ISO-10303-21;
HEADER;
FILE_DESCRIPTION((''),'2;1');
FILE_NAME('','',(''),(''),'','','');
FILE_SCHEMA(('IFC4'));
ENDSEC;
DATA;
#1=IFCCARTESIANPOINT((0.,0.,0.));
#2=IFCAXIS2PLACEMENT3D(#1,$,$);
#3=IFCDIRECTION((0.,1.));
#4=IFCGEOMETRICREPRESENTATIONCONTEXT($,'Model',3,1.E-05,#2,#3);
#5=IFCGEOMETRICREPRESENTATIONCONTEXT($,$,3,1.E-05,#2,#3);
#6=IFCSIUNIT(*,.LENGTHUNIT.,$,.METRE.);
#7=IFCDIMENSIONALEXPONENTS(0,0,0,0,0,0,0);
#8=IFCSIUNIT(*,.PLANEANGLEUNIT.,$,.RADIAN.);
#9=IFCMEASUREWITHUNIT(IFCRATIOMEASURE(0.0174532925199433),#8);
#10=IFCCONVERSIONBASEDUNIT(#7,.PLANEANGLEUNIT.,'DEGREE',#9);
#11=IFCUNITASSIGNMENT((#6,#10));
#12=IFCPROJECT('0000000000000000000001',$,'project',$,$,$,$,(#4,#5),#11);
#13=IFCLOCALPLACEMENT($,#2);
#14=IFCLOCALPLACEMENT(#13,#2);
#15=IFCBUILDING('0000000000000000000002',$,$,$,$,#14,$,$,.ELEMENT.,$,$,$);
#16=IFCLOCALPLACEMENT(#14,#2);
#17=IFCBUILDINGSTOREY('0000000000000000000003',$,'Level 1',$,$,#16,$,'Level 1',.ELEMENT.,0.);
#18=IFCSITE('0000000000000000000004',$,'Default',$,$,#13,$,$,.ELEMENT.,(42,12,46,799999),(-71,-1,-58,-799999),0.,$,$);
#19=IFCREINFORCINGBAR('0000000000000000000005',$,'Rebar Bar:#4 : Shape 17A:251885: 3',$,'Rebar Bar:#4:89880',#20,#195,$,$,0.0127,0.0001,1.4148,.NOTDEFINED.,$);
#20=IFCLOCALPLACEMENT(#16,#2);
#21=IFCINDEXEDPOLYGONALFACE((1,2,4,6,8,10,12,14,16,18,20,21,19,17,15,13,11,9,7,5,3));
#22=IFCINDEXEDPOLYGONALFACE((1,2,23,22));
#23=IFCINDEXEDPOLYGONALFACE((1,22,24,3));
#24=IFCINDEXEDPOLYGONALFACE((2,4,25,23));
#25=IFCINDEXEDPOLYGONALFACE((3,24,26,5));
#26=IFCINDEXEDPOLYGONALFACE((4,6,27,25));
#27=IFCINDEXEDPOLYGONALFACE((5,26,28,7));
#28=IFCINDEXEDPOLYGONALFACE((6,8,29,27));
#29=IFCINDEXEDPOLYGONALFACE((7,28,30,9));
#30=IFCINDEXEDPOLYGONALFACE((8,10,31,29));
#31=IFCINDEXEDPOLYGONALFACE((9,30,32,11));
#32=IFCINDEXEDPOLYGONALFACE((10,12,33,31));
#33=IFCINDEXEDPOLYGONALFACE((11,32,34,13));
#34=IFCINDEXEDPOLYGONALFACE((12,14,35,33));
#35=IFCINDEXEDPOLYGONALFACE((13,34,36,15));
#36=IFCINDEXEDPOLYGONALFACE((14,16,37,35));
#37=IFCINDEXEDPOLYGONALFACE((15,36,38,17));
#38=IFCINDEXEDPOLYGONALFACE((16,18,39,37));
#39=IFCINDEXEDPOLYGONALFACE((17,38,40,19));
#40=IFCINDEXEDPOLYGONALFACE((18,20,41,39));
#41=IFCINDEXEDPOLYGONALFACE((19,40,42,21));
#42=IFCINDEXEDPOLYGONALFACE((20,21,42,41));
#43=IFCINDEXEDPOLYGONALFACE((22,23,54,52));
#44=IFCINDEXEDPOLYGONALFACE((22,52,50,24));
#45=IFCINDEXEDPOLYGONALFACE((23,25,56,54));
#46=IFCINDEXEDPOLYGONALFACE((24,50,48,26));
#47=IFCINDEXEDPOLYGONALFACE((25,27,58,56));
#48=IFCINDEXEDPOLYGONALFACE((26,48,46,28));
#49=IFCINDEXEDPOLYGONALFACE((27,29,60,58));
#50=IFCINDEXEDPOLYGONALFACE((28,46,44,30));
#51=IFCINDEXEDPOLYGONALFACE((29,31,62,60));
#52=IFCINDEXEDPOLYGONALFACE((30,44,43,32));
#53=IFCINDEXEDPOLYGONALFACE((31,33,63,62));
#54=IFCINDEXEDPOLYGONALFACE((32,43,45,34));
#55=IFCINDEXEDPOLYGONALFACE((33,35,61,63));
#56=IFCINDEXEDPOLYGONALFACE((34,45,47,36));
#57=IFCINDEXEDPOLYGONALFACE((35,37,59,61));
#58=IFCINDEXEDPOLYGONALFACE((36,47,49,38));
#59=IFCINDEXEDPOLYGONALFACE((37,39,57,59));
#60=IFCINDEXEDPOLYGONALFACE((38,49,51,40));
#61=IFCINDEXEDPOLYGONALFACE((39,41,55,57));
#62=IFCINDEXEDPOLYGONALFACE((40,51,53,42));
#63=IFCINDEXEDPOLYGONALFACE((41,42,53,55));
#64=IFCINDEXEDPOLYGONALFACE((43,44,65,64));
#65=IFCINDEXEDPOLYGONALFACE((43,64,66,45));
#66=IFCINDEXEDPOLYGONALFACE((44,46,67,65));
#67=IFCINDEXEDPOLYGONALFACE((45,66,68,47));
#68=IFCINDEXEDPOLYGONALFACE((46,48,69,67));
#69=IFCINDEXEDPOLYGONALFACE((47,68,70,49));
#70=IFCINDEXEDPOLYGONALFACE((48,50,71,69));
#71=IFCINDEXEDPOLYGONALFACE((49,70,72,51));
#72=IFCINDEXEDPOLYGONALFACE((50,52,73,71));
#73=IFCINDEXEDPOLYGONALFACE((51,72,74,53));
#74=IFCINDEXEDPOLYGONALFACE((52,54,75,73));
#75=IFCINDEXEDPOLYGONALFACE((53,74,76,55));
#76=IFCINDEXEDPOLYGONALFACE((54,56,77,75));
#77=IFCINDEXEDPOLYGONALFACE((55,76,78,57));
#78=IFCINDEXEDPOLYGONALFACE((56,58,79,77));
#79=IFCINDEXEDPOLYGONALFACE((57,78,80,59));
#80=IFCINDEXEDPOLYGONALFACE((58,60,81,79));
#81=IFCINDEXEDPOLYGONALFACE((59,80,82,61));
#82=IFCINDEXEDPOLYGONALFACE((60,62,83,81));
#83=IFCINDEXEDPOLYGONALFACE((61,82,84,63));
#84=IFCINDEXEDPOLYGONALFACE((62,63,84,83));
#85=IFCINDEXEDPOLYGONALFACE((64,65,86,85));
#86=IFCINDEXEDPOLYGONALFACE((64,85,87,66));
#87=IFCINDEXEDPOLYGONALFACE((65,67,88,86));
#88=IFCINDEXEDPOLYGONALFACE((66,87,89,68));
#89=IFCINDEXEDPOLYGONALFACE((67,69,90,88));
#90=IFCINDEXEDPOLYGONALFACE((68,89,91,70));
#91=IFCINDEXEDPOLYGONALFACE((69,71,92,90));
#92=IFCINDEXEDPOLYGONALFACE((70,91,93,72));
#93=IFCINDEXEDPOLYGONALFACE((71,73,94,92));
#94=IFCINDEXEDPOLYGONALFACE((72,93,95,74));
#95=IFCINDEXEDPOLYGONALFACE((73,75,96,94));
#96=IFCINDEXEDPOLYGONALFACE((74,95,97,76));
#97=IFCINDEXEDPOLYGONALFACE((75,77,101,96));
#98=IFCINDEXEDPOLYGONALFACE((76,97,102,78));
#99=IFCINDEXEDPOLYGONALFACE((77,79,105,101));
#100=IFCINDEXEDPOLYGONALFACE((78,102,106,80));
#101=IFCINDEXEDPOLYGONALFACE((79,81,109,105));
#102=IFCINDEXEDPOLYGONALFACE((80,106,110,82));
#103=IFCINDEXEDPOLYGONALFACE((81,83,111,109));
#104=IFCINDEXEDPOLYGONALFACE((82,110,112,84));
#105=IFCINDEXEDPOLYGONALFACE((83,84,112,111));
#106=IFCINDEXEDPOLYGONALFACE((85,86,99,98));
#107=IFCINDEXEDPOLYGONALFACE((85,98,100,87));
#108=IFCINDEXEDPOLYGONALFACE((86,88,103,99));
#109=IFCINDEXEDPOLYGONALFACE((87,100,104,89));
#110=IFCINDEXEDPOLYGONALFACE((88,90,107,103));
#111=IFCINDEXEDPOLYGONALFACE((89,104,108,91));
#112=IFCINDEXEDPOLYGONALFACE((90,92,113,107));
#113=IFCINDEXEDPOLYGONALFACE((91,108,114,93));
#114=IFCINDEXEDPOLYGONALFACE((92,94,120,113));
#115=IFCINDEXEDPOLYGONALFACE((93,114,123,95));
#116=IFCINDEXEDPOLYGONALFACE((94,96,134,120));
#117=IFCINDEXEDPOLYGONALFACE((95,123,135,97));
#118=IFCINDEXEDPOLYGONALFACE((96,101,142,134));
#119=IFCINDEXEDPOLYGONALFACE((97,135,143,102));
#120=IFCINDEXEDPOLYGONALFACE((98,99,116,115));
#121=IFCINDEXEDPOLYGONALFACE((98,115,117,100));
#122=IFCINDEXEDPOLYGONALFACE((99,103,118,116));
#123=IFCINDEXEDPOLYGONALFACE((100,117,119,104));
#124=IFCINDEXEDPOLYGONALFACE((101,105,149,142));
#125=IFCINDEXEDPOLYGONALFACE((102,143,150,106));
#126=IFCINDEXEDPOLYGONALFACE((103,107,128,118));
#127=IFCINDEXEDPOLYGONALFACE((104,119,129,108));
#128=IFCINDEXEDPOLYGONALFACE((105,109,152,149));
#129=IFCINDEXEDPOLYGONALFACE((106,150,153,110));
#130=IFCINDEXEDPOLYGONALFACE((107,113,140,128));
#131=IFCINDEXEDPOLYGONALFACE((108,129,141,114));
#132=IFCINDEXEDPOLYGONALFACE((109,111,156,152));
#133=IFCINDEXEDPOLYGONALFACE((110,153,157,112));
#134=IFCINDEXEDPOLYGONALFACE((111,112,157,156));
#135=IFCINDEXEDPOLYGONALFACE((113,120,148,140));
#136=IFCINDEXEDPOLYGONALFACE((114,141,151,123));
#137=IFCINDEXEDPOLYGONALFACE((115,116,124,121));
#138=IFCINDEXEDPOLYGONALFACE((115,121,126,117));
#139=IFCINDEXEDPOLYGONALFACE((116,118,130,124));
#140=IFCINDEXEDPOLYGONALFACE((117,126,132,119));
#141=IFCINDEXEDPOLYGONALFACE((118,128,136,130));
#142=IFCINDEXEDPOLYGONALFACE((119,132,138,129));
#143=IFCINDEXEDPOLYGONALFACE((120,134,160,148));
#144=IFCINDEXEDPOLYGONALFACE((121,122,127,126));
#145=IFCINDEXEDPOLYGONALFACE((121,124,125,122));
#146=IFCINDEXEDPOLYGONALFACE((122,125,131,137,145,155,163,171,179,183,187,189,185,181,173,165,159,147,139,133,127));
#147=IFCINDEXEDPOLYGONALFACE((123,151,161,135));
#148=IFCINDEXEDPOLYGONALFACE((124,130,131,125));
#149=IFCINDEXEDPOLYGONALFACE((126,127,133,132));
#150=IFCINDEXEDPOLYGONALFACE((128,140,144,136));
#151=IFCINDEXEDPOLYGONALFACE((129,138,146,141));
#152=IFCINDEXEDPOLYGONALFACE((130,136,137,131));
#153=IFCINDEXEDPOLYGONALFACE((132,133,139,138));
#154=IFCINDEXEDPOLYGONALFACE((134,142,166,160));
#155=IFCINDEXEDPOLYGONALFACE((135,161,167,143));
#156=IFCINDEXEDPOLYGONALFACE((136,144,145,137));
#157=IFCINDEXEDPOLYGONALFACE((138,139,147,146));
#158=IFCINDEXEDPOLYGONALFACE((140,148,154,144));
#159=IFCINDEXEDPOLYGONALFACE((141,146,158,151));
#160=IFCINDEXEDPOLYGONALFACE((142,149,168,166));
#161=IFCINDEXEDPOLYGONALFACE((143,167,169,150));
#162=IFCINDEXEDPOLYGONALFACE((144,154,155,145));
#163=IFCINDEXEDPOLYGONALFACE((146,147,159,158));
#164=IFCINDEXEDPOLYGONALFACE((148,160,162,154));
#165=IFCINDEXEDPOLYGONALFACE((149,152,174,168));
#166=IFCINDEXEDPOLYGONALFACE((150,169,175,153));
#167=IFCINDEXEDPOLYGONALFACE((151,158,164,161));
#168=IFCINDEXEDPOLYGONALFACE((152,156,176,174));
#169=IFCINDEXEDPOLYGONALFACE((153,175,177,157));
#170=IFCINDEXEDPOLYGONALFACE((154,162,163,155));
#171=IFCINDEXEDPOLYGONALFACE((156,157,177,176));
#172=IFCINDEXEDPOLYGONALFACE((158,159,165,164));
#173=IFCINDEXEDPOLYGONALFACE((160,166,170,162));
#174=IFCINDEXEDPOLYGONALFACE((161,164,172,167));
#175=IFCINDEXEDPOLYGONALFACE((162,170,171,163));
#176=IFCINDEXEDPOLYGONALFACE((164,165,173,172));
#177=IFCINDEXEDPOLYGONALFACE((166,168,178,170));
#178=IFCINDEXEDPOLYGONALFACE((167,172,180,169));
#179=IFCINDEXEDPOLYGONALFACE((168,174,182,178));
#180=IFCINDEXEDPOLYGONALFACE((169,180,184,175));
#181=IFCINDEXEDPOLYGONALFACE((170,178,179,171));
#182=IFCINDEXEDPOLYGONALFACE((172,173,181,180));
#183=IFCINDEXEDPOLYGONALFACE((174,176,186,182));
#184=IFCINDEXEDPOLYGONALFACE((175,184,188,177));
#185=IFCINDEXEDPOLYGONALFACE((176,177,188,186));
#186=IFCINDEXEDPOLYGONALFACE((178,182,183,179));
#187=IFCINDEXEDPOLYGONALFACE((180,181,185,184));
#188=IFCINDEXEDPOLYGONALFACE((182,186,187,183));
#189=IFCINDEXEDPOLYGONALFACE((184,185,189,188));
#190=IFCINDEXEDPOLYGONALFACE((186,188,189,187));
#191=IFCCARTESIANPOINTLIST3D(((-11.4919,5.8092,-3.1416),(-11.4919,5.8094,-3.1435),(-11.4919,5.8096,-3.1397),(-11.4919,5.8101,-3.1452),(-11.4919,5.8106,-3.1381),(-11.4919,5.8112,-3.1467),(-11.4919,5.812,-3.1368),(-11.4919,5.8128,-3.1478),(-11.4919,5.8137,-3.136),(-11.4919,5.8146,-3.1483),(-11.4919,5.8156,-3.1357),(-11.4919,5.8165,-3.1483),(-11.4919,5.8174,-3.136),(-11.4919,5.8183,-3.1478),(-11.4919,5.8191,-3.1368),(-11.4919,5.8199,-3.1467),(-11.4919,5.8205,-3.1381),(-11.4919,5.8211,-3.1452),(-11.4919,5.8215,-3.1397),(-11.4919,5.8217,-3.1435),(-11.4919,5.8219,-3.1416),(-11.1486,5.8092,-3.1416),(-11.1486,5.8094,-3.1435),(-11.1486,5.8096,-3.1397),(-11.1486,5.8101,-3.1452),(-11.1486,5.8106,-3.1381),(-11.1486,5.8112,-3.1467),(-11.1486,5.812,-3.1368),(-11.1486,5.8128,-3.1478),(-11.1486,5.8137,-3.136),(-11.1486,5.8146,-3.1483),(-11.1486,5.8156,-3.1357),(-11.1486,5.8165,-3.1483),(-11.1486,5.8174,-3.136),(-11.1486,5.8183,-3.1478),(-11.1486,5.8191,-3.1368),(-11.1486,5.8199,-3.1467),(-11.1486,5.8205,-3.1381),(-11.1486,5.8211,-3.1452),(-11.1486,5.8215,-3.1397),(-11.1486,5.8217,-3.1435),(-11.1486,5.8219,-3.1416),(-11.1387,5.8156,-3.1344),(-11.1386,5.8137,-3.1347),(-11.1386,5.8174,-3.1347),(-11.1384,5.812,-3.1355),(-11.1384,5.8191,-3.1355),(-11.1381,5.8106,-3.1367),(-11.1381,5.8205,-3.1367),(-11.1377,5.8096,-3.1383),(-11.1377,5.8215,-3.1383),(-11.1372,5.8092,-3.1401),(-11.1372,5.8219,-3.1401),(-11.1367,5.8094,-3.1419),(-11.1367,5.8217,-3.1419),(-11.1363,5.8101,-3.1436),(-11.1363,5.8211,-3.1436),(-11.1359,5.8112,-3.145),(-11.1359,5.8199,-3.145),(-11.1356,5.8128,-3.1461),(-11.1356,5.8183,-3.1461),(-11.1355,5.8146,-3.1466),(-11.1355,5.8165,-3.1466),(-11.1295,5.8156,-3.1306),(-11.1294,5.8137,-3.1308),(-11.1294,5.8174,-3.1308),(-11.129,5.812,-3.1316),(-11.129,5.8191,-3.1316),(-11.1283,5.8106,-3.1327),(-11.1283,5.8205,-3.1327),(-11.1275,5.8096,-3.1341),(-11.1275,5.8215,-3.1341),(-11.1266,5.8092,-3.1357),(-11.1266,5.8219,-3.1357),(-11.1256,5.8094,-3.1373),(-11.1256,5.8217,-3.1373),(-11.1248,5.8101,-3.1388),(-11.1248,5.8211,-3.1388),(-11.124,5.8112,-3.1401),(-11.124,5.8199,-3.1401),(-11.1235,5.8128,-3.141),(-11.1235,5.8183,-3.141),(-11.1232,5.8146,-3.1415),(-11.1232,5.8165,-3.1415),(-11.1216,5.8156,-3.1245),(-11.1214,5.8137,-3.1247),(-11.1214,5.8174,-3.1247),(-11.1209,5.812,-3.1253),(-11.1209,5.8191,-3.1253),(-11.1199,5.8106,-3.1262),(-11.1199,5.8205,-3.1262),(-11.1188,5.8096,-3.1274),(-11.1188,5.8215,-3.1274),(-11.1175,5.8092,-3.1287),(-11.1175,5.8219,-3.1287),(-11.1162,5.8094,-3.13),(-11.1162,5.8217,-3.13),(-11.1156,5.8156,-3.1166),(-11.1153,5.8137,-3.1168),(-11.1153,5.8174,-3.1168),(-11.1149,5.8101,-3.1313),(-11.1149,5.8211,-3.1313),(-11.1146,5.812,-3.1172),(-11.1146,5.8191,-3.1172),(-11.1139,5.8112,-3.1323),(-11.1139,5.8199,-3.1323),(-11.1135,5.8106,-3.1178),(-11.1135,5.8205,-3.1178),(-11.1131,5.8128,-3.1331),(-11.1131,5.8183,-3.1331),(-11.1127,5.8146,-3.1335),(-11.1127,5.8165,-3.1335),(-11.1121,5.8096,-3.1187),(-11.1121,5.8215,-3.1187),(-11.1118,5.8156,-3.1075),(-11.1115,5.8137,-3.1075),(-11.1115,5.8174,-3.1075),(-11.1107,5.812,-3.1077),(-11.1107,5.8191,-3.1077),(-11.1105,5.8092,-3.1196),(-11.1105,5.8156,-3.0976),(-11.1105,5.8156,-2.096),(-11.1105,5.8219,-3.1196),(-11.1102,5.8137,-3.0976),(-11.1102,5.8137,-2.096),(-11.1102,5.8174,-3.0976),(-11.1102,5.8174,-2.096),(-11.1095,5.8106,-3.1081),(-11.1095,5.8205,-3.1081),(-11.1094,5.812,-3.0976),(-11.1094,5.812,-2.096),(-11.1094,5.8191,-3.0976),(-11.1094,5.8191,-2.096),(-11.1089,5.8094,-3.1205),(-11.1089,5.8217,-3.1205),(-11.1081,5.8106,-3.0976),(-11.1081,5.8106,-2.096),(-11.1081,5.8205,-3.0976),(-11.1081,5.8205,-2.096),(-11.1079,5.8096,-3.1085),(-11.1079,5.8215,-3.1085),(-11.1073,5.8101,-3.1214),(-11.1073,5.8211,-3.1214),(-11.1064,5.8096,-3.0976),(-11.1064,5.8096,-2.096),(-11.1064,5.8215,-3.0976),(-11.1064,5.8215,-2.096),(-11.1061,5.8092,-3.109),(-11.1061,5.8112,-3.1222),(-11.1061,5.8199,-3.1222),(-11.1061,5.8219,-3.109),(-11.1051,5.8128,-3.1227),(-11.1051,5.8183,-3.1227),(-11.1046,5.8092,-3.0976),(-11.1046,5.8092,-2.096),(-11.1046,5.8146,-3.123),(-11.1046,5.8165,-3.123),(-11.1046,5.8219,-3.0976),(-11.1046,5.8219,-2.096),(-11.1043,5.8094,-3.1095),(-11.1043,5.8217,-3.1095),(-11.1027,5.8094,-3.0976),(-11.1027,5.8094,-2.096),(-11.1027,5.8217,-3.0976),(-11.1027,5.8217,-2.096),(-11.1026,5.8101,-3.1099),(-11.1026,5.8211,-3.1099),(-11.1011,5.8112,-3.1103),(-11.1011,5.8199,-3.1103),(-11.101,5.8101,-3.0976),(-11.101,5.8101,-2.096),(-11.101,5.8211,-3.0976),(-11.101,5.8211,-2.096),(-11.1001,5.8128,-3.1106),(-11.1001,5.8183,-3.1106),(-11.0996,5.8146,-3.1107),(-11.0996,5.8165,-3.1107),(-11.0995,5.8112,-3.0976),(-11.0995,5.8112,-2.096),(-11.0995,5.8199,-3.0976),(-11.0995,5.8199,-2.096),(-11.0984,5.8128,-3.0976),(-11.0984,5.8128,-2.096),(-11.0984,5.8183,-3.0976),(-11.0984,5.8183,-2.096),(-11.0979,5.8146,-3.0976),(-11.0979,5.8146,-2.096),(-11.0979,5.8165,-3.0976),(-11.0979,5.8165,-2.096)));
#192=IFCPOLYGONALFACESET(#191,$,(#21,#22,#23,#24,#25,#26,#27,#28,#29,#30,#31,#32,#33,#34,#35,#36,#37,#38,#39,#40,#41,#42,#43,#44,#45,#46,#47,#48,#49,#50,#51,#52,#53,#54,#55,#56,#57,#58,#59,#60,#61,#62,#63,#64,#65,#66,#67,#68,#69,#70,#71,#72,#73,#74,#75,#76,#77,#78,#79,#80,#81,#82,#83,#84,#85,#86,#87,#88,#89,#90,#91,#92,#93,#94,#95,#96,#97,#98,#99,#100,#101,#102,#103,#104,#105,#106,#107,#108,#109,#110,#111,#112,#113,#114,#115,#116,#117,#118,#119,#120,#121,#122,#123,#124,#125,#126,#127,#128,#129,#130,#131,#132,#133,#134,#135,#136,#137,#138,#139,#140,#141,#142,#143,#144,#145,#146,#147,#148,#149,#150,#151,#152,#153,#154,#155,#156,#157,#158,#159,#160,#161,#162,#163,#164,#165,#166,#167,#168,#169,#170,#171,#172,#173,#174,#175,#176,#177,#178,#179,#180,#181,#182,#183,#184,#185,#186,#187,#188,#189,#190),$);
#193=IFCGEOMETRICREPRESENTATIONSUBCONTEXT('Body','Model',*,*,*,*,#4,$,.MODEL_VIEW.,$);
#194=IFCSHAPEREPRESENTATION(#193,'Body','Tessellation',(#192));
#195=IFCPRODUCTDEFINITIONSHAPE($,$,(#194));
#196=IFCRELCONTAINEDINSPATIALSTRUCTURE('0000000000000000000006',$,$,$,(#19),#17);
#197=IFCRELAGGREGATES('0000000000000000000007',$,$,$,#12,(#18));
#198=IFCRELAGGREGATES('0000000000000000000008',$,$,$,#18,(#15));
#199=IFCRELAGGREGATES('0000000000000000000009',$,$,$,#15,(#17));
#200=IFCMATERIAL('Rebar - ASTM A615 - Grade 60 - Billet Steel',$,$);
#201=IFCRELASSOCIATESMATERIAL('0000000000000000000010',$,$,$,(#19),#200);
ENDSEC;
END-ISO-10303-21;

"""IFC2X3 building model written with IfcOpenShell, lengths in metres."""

from ifc_helpers import new_model, entity, si_unit, converted_unit, direction, origin, place, context, subcontext, project, spatial, material, element, save


model = new_model("IFC2X3")

# Units and contexts
model_context = context("Model", 3, precision=1e-05, world=origin(), true_north=direction((0.0, 1.0)))
context_of_model = context(None, 3, precision=1e-05, world=origin(), true_north=direction((0.0, 1.0)))
body_context = subcontext(model_context, "Body", "Model", "MODEL_VIEW")
ifc_project = project(units=[si_unit("LENGTHUNIT", "METRE"), converted_unit("PLANEANGLEUNIT", "DEGREE", entity("IfcRatioMeasure", 0.0174532925199433), si_unit("PLANEANGLEUNIT", "RADIAN"), dimensions=[0, 0, 0, 0, 0, 0, 0])], contexts=[model_context, context_of_model])

# Site, building, storey
site_placement = place(None, origin())
site = spatial("IfcSite", under=ifc_project, at=site_placement, Name="Default", CompositionType="ELEMENT", RefLatitude=(42, 12, 46, 799999), RefLongitude=(-71, -1, -58, -799999), RefElevation=0.0)
building_placement = place(site_placement, origin())
building = spatial("IfcBuilding", under=site, at=building_placement, CompositionType="ELEMENT")
storey_placement = place(building_placement, origin())
storey = spatial("IfcBuildingStorey", under=building, at=storey_placement, Name="Level 1", LongName="Level 1", CompositionType="ELEMENT", Elevation=0.0)

# Reinforcing bar
ifc_material_1 = material(Name="Rebar - ASTM A615 - Grade 60 - Billet Steel")
reinforcing_bar_1_placement = place(storey_placement, origin())
element("IfcReinforcingBar", 1, at=reinforcing_bar_1_placement, inside=storey, material=ifc_material_1, Name="Rebar Bar:#4 : Shape 17A:251885: 3", ObjectType="Rebar Bar:#4:89880", BarLength=1.4148, BarRole="NOTDEFINED", CrossSectionArea=0.0001, NominalDiameter=0.0127, context=body_context, shape_type="AdvancedSweptSolid", body=[
    entity("IfcSweptDiskSolid", entity("IfcCompositeCurve", [entity("IfcCompositeCurveSegment", "CONTINUOUS", True, entity("IfcPolyline", [entity("IfcCartesianPoint", [-11.4919, 5.8156, -3.142]), entity("IfcCartesianPoint", [-11.1486, 5.8156, -3.142])])), entity("IfcCompositeCurveSegment", "CONTINUOUS", True, entity("IfcTrimmedCurve", entity("IfcCircle", entity("IfcAxis2Placement3D", entity("IfcCartesianPoint", [-11.1486, 5.8156, -3.0976]), entity("IfcDirection", [0.0, -1.0, 0.0]), entity("IfcDirection", [1.0, 0.0, 0.0])), 0.0445), [entity("IfcParameterValue", 270.0)], [entity("IfcParameterValue", 360.0)], True, "PARAMETER")), entity("IfcCompositeCurveSegment", "CONTINUOUS", True, entity("IfcPolyline", [entity("IfcCartesianPoint", [-11.1041, 5.8156, -3.0976]), entity("IfcCartesianPoint", [-11.1041, 5.8156, -2.096])]))], False), 0.0063, None, 0.0, 92.0),
])

save(model, "model.ifc")
